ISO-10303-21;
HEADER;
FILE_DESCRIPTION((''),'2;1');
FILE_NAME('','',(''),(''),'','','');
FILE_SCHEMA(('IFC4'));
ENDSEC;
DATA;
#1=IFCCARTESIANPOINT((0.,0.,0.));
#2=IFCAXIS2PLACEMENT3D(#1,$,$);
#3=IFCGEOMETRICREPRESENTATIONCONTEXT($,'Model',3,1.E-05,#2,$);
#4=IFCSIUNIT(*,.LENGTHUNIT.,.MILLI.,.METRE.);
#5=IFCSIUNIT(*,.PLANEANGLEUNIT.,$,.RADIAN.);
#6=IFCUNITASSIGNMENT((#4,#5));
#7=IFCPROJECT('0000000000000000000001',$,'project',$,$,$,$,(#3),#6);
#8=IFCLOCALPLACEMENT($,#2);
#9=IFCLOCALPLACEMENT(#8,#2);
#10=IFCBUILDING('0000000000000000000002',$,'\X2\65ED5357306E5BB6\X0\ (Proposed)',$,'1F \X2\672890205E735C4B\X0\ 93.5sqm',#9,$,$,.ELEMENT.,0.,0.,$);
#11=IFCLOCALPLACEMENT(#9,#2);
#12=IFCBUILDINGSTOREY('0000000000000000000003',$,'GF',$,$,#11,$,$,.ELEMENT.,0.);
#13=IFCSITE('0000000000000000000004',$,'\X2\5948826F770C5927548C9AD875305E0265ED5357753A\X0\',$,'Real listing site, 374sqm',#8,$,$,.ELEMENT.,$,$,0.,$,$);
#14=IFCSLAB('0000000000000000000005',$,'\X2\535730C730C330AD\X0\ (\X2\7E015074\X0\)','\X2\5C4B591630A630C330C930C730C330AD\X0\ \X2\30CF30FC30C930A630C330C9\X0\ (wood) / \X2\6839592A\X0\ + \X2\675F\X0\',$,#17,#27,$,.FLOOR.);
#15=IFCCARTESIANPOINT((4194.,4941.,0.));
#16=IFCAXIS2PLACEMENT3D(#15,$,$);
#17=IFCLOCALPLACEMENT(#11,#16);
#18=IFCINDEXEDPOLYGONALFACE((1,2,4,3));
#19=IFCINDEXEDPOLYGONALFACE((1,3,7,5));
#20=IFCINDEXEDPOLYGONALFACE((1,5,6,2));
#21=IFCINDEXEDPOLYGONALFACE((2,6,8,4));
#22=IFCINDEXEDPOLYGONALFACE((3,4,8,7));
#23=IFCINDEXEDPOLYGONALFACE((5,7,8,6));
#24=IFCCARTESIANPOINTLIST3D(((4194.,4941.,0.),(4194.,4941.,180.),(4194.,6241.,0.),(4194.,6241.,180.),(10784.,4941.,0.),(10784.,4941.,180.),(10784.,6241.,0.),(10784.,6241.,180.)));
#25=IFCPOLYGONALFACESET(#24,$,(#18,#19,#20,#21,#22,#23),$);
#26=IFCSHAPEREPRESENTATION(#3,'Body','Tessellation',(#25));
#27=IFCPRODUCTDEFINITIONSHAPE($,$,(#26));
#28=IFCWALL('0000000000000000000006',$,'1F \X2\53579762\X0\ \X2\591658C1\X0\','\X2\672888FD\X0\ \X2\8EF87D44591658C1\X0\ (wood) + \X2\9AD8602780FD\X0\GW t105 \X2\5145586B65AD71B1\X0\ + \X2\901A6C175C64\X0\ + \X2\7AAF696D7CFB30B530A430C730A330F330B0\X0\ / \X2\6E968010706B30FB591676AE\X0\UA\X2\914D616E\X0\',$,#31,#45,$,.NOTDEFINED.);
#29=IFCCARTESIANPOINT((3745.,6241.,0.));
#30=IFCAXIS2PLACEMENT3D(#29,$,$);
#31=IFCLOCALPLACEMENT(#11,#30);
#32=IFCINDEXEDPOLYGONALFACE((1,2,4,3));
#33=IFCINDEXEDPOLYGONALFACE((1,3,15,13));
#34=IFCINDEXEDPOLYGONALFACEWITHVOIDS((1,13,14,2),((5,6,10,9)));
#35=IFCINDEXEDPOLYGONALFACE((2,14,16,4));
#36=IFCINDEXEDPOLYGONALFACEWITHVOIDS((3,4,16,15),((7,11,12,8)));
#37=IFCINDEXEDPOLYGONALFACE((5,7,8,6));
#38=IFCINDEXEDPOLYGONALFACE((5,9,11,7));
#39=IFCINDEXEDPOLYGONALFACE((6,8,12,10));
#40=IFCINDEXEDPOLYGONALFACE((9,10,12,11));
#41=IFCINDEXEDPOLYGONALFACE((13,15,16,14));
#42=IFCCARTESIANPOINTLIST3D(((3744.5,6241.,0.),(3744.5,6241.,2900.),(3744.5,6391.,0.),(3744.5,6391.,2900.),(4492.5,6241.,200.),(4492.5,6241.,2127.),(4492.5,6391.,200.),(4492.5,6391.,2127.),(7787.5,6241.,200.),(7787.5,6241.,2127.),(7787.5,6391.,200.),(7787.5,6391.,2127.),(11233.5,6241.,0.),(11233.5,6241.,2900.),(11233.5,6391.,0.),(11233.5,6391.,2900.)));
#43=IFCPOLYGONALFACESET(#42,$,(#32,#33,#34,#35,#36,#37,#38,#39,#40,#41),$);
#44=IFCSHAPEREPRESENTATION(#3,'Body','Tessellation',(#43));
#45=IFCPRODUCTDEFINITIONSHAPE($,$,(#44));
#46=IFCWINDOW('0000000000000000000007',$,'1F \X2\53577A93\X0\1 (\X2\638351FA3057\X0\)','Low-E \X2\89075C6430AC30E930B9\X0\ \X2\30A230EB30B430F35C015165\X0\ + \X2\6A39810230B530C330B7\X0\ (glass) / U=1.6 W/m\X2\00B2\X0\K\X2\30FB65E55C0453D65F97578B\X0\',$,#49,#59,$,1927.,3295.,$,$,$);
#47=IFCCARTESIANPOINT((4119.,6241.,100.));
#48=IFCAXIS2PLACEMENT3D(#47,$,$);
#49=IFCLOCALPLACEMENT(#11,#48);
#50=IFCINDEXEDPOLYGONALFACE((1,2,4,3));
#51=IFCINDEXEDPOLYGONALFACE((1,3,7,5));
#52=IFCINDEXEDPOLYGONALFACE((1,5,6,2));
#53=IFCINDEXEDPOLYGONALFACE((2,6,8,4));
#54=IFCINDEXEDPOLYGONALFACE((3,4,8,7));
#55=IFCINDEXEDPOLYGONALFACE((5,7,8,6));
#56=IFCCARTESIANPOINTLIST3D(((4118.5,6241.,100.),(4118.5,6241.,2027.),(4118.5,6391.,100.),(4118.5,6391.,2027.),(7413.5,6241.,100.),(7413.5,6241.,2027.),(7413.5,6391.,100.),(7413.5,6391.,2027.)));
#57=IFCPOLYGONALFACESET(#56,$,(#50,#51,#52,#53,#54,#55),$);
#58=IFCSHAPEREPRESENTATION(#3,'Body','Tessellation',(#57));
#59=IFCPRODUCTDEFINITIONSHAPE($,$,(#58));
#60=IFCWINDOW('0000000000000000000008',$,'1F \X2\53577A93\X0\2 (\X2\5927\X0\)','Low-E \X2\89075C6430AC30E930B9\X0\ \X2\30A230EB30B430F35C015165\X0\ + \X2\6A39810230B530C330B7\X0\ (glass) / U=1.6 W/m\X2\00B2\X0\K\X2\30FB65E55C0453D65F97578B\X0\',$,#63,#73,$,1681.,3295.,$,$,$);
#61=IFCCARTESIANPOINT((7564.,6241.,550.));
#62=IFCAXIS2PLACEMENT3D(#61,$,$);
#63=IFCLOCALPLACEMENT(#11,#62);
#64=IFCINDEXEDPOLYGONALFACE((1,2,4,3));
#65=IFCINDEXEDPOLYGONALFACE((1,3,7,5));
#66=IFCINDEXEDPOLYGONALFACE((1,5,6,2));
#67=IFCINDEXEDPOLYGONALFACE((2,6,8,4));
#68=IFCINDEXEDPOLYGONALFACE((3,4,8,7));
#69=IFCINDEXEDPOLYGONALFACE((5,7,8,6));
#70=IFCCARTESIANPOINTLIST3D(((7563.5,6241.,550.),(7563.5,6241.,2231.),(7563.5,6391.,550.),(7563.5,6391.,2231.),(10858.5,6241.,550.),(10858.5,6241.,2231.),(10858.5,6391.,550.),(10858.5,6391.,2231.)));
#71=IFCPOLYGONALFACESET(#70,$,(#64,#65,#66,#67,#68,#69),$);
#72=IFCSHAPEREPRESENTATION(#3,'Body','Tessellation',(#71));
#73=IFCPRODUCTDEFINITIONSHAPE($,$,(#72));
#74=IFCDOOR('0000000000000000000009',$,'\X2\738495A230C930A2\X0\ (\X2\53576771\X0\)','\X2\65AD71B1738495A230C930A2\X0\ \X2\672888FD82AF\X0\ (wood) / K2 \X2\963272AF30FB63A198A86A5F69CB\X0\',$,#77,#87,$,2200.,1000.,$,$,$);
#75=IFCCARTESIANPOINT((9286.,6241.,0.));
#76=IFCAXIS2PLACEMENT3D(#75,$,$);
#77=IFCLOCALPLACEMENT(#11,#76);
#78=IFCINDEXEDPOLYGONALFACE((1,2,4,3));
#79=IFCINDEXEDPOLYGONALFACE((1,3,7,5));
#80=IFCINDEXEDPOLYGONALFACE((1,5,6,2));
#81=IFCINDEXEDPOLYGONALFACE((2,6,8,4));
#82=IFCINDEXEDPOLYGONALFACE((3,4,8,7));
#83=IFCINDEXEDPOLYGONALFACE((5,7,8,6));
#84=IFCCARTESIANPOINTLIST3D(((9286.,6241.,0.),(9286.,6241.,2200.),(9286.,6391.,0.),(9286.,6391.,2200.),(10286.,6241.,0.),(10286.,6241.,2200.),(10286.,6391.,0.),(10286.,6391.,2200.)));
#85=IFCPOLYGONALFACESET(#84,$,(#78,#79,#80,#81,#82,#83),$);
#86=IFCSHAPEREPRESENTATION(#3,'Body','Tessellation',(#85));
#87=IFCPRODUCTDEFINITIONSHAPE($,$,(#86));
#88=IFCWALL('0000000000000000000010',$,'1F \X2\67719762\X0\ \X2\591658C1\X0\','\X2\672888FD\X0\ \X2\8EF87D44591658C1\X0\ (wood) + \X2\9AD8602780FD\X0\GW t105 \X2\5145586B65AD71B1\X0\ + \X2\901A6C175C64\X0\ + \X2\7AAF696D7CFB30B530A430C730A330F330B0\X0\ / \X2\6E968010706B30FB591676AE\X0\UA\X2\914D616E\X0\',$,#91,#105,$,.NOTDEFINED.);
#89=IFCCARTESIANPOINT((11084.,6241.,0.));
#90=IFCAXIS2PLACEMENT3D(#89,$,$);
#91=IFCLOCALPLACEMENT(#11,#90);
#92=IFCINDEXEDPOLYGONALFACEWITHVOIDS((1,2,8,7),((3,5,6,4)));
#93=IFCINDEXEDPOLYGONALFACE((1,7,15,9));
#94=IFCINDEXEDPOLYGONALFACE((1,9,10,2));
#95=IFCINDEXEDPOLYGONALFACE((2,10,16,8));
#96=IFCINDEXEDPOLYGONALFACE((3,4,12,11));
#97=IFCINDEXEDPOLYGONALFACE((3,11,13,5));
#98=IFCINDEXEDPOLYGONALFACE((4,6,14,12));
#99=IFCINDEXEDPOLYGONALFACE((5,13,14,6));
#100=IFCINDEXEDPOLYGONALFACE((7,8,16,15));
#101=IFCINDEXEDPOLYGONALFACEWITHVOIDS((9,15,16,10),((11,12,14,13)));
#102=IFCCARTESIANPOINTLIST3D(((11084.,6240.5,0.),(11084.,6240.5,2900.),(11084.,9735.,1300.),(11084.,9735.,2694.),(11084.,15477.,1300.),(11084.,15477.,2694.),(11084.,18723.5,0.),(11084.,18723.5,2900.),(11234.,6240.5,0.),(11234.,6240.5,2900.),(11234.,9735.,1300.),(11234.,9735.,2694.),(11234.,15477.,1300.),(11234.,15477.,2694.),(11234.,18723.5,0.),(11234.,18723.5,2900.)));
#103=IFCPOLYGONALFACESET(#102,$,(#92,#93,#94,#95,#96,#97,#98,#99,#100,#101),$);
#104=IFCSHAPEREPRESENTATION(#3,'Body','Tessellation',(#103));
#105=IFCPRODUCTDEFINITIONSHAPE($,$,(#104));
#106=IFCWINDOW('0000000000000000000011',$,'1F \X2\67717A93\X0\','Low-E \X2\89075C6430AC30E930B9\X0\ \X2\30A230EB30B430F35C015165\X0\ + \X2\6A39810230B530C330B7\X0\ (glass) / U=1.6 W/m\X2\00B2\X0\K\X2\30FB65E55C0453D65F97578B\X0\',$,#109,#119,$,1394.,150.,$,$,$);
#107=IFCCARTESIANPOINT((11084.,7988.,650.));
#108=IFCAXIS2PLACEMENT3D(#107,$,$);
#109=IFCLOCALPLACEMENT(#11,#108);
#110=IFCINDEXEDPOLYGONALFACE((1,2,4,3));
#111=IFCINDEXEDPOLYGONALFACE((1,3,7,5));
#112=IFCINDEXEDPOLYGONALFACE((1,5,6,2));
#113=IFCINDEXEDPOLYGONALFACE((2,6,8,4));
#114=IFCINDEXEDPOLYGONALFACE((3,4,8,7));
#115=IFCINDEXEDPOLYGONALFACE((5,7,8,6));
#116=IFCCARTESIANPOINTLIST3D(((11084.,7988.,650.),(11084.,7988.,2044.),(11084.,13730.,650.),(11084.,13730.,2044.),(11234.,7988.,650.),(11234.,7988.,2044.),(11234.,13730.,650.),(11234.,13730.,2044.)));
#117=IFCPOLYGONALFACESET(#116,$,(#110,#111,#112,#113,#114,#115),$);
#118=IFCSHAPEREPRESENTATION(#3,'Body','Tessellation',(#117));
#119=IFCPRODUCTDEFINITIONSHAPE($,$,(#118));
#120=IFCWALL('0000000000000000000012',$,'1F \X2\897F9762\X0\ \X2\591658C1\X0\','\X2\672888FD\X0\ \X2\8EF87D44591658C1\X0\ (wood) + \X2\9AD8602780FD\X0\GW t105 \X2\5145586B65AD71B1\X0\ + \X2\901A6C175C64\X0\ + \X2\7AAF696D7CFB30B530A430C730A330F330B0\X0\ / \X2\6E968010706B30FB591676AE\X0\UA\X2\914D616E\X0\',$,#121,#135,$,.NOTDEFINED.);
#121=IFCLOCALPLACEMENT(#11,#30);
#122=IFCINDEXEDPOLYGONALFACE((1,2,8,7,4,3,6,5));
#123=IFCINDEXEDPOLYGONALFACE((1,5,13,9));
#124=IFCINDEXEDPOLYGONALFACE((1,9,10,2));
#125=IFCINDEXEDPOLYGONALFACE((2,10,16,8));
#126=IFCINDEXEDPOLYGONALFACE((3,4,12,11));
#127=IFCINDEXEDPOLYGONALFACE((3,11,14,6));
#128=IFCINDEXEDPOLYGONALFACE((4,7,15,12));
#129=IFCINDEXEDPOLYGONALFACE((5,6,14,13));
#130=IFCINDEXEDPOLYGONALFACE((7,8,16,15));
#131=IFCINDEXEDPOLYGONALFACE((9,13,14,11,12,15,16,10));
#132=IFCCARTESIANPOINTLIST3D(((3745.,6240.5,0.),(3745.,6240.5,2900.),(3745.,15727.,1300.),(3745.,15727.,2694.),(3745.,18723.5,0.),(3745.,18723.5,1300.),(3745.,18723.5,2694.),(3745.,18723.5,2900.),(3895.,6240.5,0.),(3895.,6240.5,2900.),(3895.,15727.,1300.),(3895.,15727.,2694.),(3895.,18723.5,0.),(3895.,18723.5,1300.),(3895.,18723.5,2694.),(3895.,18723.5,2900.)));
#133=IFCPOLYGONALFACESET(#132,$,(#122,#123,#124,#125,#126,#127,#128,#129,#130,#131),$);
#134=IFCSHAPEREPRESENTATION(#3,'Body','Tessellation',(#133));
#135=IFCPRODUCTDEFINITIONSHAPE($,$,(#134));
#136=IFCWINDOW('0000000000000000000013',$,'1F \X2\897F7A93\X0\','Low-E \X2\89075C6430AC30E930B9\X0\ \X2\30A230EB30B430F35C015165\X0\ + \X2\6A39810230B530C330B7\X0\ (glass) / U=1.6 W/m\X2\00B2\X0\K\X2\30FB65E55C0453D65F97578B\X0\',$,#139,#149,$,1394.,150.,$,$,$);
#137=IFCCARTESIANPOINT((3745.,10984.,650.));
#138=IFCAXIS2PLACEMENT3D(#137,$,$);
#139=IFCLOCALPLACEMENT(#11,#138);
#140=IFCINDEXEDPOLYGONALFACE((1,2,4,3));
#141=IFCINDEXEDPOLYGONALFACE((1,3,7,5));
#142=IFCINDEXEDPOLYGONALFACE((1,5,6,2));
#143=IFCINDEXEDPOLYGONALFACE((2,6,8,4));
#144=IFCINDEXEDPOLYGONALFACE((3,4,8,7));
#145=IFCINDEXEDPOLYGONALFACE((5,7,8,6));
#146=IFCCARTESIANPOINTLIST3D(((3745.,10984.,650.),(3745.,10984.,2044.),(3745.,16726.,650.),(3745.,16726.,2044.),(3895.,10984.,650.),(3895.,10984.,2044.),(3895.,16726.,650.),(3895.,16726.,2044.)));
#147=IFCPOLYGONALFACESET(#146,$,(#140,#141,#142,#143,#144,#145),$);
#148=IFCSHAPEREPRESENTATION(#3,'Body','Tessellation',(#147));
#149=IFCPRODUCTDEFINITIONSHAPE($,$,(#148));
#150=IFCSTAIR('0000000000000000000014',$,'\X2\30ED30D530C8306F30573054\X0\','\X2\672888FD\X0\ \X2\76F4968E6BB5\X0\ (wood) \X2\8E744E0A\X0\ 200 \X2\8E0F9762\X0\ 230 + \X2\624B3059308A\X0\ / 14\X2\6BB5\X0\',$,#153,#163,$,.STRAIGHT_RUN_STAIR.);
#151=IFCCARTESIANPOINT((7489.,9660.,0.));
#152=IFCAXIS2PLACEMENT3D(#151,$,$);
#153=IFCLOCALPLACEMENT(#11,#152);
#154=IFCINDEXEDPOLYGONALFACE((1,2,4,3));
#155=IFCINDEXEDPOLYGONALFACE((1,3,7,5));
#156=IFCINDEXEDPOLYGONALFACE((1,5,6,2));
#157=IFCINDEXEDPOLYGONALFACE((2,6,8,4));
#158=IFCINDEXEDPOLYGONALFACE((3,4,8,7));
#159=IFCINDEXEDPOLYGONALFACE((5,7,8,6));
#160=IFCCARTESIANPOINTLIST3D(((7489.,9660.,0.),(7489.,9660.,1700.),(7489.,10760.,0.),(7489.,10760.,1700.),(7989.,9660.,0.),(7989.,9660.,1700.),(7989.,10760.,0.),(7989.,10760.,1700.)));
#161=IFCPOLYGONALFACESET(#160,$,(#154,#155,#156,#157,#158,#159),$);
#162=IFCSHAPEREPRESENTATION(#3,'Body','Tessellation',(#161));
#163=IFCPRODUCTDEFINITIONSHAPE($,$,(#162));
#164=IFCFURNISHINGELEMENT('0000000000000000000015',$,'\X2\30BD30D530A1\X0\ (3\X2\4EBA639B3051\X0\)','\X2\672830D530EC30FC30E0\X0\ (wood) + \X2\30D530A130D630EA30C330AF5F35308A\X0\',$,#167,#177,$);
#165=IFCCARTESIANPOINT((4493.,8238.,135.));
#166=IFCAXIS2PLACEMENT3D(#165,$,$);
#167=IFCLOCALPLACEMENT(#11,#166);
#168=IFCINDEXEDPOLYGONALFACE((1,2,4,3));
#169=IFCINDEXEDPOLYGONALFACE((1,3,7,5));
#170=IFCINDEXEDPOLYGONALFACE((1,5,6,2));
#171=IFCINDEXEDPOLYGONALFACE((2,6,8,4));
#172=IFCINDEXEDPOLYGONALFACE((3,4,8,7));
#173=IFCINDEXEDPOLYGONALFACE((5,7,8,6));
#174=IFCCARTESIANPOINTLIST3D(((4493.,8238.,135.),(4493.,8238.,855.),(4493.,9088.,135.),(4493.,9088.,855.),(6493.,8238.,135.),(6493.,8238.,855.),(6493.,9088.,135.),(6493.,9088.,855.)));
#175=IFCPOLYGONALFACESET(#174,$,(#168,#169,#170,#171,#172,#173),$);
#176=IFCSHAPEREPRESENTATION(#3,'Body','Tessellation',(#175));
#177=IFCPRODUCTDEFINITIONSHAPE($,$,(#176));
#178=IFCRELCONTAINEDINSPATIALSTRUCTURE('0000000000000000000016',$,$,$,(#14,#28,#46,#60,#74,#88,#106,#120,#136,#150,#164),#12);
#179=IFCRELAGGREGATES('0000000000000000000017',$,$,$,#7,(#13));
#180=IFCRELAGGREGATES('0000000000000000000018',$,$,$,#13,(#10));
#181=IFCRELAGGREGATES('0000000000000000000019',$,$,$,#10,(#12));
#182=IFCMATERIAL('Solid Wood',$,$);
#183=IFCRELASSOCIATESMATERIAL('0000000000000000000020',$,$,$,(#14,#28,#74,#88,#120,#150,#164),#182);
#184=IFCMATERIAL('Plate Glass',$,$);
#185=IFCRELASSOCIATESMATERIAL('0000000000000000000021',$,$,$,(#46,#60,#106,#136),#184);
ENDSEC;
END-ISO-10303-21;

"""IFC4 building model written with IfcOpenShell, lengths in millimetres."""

from ifc_helpers import new_model, si_unit, frame, frame_2d, origin, place, context, project, spatial, rectangle, extrude, material, element, fill, save


model = new_model("IFC4")

# Units and contexts
model_context = context("Model", 3, precision=1e-05, world=origin())
ifc_project = project(units=[si_unit("LENGTHUNIT", "METRE", prefix="MILLI"), si_unit("PLANEANGLEUNIT", "RADIAN")], contexts=[model_context])

# Site, building, storey
site_placement = place(None, origin())
site = spatial("IfcSite", under=ifc_project, at=site_placement, Name="奈良県大和高田市旭南町", ObjectType="Real listing site, 374sqm", CompositionType="ELEMENT", RefElevation=0.0)
building_placement = place(site_placement, origin())
building = spatial("IfcBuilding", under=site, at=building_placement, Name="旭南の家 (Proposed)", ObjectType="1F 木造平屋 93.5sqm", CompositionType="ELEMENT", ElevationOfRefHeight=0.0, ElevationOfTerrain=0.0)
storey_placement = place(building_placement, origin())
storey = spatial("IfcBuildingStorey", under=building, at=storey_placement, Name="GF", CompositionType="ELEMENT", Elevation=0.0)

# Slab
ifc_material_1 = material(Name="Solid Wood")
slab_1_placement = place(storey_placement, frame((4194.0, 4941.0, 0.0)))
element("IfcSlab", 1, at=slab_1_placement, inside=storey, material=ifc_material_1, Name="南デッキ (縁側)", Description="屋外ウッドデッキ ハードウッド (wood) / 根太 + 束", PredefinedType="FLOOR", context=model_context, shape_type="SweptSolid", body=[
    extrude(rectangle(XDim=6590.0, YDim=1300.0, at=frame_2d((3295.0, 650.0))), frame((4194.0, 4941.0, 0.0)), (0.0, 0.0, 1.0), 180.0),
])

# Wall, openings, windows, door
wall_1_placement = place(storey_placement, frame((3745.0, 6241.0, 0.0)))
wall_1 = element("IfcWall", 2, at=wall_1_placement, inside=storey, material=ifc_material_1, Name="1F 南面 外壁", Description="木製 軸組外壁 (wood) + 高性能GW t105 充填断熱 + 通気層 + 窯業系サイディング / 準耐火・外皮UA配慮", PredefinedType="NOTDEFINED", context=model_context, shape_type="SweptSolid", body=[
    extrude(rectangle(XDim=7489.0, YDim=150.0, at=frame_2d((3744.0, 75.0))), frame((3745.0, 6241.0, 0.0)), (0.0, 0.0, 1.0), 2900.0),
])
opening_1_placement = place(storey_placement, frame((4119.0, 6241.0, 100.0)))
opening_1 = element("IfcOpeningElement", 3, at=opening_1_placement, cuts=wall_1, PredefinedType="NOTDEFINED", context=model_context, shape_type="SweptSolid", body=[
    extrude(rectangle(XDim=3295.0, YDim=150.0, at=frame_2d((1647.0, 75.0))), frame((4119.0, 6241.0, 100.0)), (0.0, 0.0, 1.0), 1927.0),
])
opening_2_placement = place(storey_placement, frame((7564.0, 6241.0, 550.0)))
opening_2 = element("IfcOpeningElement", 4, at=opening_2_placement, cuts=wall_1, PredefinedType="NOTDEFINED", context=model_context, shape_type="SweptSolid", body=[
    extrude(rectangle(XDim=3295.0, YDim=150.0, at=frame_2d((1647.0, 75.0))), frame((7564.0, 6241.0, 550.0)), (0.0, 0.0, 1.0), 1681.0),
])
opening_3_placement = place(storey_placement, frame((9286.0, 6241.0, 0.0)))
opening_3 = element("IfcOpeningElement", 5, at=opening_3_placement, cuts=wall_1, PredefinedType="NOTDEFINED", context=model_context, shape_type="SweptSolid", body=[
    extrude(rectangle(XDim=1000.0, YDim=150.0, at=frame_2d((500.0, 75.0))), frame((9286.0, 6241.0, 0.0)), (0.0, 0.0, 1.0), 2200.0),
])
ifc_material_2 = material(Name="Plate Glass")
window_1_placement = place(storey_placement, frame((4119.0, 6241.0, 100.0)))
window_1 = element("IfcWindow", 6, at=window_1_placement, inside=storey, material=ifc_material_2, Name="1F 南窓1 (掃出し)", Description="Low-E 複層ガラス アルゴン封入 + 樹脂サッシ (glass) / U=1.6 W/m²K・日射取得型", OverallHeight=1927.0, OverallWidth=3295.0, context=model_context, shape_type="SweptSolid", body=[
    extrude(rectangle(XDim=3295.0, YDim=150.0, at=frame_2d((1647.0, 75.0))), frame((4119.0, 6241.0, 100.0)), (0.0, 0.0, 1.0), 1927.0),
])
fill(opening_1, window_1)
window_2_placement = place(storey_placement, frame((7564.0, 6241.0, 550.0)))
window_2 = element("IfcWindow", 7, at=window_2_placement, inside=storey, material=ifc_material_2, Name="1F 南窓2 (大)", Description="Low-E 複層ガラス アルゴン封入 + 樹脂サッシ (glass) / U=1.6 W/m²K・日射取得型", OverallHeight=1681.0, OverallWidth=3295.0, context=model_context, shape_type="SweptSolid", body=[
    extrude(rectangle(XDim=3295.0, YDim=150.0, at=frame_2d((1647.0, 75.0))), frame((7564.0, 6241.0, 550.0)), (0.0, 0.0, 1.0), 1681.0),
])
fill(opening_2, window_2)
door_placement = place(storey_placement, frame((9286.0, 6241.0, 0.0)))
door = element("IfcDoor", 8, at=door_placement, inside=storey, material=ifc_material_1, Name="玄関ドア (南東)", Description="断熱玄関ドア 木製芯 (wood) / K2 防犯・採風機構", OverallHeight=2200.0, OverallWidth=1000.0, context=model_context, shape_type="SweptSolid", body=[
    extrude(rectangle(XDim=1000.0, YDim=150.0, at=frame_2d((500.0, 75.0))), frame((9286.0, 6241.0, 0.0)), (0.0, 0.0, 1.0), 2200.0),
])
fill(opening_3, door)

# Walls, openings, windows
wall_2_placement = place(storey_placement, frame((11084.0, 6241.0, 0.0)))
wall_2 = element("IfcWall", 9, at=wall_2_placement, inside=storey, material=ifc_material_1, Name="1F 東面 外壁", Description="木製 軸組外壁 (wood) + 高性能GW t105 充填断熱 + 通気層 + 窯業系サイディング / 準耐火・外皮UA配慮", PredefinedType="NOTDEFINED", context=model_context, shape_type="SweptSolid", body=[
    extrude(rectangle(XDim=150.0, YDim=12483.0, at=frame_2d((75.0, 6241.0))), frame((11084.0, 6241.0, 0.0)), (0.0, 0.0, 1.0), 2900.0),
])
opening_4_placement = place(storey_placement, frame((11084.0, 7988.0, 650.0)))
opening_4 = element("IfcOpeningElement", 10, at=opening_4_placement, cuts=wall_2, PredefinedType="NOTDEFINED", context=model_context, shape_type="SweptSolid", body=[
    extrude(rectangle(XDim=150.0, YDim=5742.0, at=frame_2d((75.0, 2871.0))), frame((11084.0, 7988.0, 650.0)), (0.0, 0.0, 1.0), 1394.0),
])
window_3_placement = place(storey_placement, frame((11084.0, 7988.0, 650.0)))
window_3 = element("IfcWindow", 11, at=window_3_placement, inside=storey, material=ifc_material_2, Name="1F 東窓", Description="Low-E 複層ガラス アルゴン封入 + 樹脂サッシ (glass) / U=1.6 W/m²K・日射取得型", OverallHeight=1394.0, OverallWidth=150.0, context=model_context, shape_type="SweptSolid", body=[
    extrude(rectangle(XDim=150.0, YDim=5742.0, at=frame_2d((75.0, 2871.0))), frame((11084.0, 7988.0, 650.0)), (0.0, 0.0, 1.0), 1394.0),
])
fill(opening_4, window_3)
wall_3_placement = place(storey_placement, frame((3745.0, 6241.0, 0.0)))
wall_3 = element("IfcWall", 12, at=wall_3_placement, inside=storey, material=ifc_material_1, Name="1F 西面 外壁", Description="木製 軸組外壁 (wood) + 高性能GW t105 充填断熱 + 通気層 + 窯業系サイディング / 準耐火・外皮UA配慮", PredefinedType="NOTDEFINED", context=model_context, shape_type="SweptSolid", body=[
    extrude(rectangle(XDim=150.0, YDim=12483.0, at=frame_2d((75.0, 6241.0))), frame((3745.0, 6241.0, 0.0)), (0.0, 0.0, 1.0), 2900.0),
])
opening_5_placement = place(storey_placement, frame((3745.0, 10984.0, 650.0)))
opening_5 = element("IfcOpeningElement", 13, at=opening_5_placement, cuts=wall_3, PredefinedType="NOTDEFINED", context=model_context, shape_type="SweptSolid", body=[
    extrude(rectangle(XDim=150.0, YDim=5742.0, at=frame_2d((75.0, 2871.0))), frame((3745.0, 10984.0, 650.0)), (0.0, 0.0, 1.0), 1394.0),
])
window_4_placement = place(storey_placement, frame((3745.0, 10984.0, 650.0)))
window_4 = element("IfcWindow", 14, at=window_4_placement, inside=storey, material=ifc_material_2, Name="1F 西窓", Description="Low-E 複層ガラス アルゴン封入 + 樹脂サッシ (glass) / U=1.6 W/m²K・日射取得型", OverallHeight=1394.0, OverallWidth=150.0, context=model_context, shape_type="SweptSolid", body=[
    extrude(rectangle(XDim=150.0, YDim=5742.0, at=frame_2d((75.0, 2871.0))), frame((3745.0, 10984.0, 650.0)), (0.0, 0.0, 1.0), 1394.0),
])
fill(opening_5, window_4)

# Stair
stair_placement = place(storey_placement, frame((7489.0, 9660.0, 0.0)))
element("IfcStair", 15, at=stair_placement, inside=storey, material=ifc_material_1, Name="ロフトはしご", Description="木製 直階段 (wood) 蹴上 200 踏面 230 + 手すり / 14段", PredefinedType="STRAIGHT_RUN_STAIR", context=model_context, shape_type="SweptSolid", body=[
    extrude(rectangle(XDim=500.0, YDim=1100.0, at=frame_2d((250.0, 550.0))), frame((7489.0, 9660.0, 0.0)), (0.0, 0.0, 1.0), 1700.0),
])

# Furnishing element
furnishing_1_placement = place(storey_placement, frame((4493.0, 8238.0, 135.0)))
element("IfcFurnishingElement", 16, at=furnishing_1_placement, inside=storey, material=ifc_material_1, Name="ソファ (3人掛け)", Description="木フレーム (wood) + ファブリック張り", context=model_context, shape_type="SweptSolid", body=[
    extrude(rectangle(XDim=2000.0, YDim=850.0, at=frame_2d((1000.0, 425.0))), frame((4493.0, 8238.0, 135.0)), (0.0, 0.0, 1.0), 720.0),
])

save(model, "model.ifc")
